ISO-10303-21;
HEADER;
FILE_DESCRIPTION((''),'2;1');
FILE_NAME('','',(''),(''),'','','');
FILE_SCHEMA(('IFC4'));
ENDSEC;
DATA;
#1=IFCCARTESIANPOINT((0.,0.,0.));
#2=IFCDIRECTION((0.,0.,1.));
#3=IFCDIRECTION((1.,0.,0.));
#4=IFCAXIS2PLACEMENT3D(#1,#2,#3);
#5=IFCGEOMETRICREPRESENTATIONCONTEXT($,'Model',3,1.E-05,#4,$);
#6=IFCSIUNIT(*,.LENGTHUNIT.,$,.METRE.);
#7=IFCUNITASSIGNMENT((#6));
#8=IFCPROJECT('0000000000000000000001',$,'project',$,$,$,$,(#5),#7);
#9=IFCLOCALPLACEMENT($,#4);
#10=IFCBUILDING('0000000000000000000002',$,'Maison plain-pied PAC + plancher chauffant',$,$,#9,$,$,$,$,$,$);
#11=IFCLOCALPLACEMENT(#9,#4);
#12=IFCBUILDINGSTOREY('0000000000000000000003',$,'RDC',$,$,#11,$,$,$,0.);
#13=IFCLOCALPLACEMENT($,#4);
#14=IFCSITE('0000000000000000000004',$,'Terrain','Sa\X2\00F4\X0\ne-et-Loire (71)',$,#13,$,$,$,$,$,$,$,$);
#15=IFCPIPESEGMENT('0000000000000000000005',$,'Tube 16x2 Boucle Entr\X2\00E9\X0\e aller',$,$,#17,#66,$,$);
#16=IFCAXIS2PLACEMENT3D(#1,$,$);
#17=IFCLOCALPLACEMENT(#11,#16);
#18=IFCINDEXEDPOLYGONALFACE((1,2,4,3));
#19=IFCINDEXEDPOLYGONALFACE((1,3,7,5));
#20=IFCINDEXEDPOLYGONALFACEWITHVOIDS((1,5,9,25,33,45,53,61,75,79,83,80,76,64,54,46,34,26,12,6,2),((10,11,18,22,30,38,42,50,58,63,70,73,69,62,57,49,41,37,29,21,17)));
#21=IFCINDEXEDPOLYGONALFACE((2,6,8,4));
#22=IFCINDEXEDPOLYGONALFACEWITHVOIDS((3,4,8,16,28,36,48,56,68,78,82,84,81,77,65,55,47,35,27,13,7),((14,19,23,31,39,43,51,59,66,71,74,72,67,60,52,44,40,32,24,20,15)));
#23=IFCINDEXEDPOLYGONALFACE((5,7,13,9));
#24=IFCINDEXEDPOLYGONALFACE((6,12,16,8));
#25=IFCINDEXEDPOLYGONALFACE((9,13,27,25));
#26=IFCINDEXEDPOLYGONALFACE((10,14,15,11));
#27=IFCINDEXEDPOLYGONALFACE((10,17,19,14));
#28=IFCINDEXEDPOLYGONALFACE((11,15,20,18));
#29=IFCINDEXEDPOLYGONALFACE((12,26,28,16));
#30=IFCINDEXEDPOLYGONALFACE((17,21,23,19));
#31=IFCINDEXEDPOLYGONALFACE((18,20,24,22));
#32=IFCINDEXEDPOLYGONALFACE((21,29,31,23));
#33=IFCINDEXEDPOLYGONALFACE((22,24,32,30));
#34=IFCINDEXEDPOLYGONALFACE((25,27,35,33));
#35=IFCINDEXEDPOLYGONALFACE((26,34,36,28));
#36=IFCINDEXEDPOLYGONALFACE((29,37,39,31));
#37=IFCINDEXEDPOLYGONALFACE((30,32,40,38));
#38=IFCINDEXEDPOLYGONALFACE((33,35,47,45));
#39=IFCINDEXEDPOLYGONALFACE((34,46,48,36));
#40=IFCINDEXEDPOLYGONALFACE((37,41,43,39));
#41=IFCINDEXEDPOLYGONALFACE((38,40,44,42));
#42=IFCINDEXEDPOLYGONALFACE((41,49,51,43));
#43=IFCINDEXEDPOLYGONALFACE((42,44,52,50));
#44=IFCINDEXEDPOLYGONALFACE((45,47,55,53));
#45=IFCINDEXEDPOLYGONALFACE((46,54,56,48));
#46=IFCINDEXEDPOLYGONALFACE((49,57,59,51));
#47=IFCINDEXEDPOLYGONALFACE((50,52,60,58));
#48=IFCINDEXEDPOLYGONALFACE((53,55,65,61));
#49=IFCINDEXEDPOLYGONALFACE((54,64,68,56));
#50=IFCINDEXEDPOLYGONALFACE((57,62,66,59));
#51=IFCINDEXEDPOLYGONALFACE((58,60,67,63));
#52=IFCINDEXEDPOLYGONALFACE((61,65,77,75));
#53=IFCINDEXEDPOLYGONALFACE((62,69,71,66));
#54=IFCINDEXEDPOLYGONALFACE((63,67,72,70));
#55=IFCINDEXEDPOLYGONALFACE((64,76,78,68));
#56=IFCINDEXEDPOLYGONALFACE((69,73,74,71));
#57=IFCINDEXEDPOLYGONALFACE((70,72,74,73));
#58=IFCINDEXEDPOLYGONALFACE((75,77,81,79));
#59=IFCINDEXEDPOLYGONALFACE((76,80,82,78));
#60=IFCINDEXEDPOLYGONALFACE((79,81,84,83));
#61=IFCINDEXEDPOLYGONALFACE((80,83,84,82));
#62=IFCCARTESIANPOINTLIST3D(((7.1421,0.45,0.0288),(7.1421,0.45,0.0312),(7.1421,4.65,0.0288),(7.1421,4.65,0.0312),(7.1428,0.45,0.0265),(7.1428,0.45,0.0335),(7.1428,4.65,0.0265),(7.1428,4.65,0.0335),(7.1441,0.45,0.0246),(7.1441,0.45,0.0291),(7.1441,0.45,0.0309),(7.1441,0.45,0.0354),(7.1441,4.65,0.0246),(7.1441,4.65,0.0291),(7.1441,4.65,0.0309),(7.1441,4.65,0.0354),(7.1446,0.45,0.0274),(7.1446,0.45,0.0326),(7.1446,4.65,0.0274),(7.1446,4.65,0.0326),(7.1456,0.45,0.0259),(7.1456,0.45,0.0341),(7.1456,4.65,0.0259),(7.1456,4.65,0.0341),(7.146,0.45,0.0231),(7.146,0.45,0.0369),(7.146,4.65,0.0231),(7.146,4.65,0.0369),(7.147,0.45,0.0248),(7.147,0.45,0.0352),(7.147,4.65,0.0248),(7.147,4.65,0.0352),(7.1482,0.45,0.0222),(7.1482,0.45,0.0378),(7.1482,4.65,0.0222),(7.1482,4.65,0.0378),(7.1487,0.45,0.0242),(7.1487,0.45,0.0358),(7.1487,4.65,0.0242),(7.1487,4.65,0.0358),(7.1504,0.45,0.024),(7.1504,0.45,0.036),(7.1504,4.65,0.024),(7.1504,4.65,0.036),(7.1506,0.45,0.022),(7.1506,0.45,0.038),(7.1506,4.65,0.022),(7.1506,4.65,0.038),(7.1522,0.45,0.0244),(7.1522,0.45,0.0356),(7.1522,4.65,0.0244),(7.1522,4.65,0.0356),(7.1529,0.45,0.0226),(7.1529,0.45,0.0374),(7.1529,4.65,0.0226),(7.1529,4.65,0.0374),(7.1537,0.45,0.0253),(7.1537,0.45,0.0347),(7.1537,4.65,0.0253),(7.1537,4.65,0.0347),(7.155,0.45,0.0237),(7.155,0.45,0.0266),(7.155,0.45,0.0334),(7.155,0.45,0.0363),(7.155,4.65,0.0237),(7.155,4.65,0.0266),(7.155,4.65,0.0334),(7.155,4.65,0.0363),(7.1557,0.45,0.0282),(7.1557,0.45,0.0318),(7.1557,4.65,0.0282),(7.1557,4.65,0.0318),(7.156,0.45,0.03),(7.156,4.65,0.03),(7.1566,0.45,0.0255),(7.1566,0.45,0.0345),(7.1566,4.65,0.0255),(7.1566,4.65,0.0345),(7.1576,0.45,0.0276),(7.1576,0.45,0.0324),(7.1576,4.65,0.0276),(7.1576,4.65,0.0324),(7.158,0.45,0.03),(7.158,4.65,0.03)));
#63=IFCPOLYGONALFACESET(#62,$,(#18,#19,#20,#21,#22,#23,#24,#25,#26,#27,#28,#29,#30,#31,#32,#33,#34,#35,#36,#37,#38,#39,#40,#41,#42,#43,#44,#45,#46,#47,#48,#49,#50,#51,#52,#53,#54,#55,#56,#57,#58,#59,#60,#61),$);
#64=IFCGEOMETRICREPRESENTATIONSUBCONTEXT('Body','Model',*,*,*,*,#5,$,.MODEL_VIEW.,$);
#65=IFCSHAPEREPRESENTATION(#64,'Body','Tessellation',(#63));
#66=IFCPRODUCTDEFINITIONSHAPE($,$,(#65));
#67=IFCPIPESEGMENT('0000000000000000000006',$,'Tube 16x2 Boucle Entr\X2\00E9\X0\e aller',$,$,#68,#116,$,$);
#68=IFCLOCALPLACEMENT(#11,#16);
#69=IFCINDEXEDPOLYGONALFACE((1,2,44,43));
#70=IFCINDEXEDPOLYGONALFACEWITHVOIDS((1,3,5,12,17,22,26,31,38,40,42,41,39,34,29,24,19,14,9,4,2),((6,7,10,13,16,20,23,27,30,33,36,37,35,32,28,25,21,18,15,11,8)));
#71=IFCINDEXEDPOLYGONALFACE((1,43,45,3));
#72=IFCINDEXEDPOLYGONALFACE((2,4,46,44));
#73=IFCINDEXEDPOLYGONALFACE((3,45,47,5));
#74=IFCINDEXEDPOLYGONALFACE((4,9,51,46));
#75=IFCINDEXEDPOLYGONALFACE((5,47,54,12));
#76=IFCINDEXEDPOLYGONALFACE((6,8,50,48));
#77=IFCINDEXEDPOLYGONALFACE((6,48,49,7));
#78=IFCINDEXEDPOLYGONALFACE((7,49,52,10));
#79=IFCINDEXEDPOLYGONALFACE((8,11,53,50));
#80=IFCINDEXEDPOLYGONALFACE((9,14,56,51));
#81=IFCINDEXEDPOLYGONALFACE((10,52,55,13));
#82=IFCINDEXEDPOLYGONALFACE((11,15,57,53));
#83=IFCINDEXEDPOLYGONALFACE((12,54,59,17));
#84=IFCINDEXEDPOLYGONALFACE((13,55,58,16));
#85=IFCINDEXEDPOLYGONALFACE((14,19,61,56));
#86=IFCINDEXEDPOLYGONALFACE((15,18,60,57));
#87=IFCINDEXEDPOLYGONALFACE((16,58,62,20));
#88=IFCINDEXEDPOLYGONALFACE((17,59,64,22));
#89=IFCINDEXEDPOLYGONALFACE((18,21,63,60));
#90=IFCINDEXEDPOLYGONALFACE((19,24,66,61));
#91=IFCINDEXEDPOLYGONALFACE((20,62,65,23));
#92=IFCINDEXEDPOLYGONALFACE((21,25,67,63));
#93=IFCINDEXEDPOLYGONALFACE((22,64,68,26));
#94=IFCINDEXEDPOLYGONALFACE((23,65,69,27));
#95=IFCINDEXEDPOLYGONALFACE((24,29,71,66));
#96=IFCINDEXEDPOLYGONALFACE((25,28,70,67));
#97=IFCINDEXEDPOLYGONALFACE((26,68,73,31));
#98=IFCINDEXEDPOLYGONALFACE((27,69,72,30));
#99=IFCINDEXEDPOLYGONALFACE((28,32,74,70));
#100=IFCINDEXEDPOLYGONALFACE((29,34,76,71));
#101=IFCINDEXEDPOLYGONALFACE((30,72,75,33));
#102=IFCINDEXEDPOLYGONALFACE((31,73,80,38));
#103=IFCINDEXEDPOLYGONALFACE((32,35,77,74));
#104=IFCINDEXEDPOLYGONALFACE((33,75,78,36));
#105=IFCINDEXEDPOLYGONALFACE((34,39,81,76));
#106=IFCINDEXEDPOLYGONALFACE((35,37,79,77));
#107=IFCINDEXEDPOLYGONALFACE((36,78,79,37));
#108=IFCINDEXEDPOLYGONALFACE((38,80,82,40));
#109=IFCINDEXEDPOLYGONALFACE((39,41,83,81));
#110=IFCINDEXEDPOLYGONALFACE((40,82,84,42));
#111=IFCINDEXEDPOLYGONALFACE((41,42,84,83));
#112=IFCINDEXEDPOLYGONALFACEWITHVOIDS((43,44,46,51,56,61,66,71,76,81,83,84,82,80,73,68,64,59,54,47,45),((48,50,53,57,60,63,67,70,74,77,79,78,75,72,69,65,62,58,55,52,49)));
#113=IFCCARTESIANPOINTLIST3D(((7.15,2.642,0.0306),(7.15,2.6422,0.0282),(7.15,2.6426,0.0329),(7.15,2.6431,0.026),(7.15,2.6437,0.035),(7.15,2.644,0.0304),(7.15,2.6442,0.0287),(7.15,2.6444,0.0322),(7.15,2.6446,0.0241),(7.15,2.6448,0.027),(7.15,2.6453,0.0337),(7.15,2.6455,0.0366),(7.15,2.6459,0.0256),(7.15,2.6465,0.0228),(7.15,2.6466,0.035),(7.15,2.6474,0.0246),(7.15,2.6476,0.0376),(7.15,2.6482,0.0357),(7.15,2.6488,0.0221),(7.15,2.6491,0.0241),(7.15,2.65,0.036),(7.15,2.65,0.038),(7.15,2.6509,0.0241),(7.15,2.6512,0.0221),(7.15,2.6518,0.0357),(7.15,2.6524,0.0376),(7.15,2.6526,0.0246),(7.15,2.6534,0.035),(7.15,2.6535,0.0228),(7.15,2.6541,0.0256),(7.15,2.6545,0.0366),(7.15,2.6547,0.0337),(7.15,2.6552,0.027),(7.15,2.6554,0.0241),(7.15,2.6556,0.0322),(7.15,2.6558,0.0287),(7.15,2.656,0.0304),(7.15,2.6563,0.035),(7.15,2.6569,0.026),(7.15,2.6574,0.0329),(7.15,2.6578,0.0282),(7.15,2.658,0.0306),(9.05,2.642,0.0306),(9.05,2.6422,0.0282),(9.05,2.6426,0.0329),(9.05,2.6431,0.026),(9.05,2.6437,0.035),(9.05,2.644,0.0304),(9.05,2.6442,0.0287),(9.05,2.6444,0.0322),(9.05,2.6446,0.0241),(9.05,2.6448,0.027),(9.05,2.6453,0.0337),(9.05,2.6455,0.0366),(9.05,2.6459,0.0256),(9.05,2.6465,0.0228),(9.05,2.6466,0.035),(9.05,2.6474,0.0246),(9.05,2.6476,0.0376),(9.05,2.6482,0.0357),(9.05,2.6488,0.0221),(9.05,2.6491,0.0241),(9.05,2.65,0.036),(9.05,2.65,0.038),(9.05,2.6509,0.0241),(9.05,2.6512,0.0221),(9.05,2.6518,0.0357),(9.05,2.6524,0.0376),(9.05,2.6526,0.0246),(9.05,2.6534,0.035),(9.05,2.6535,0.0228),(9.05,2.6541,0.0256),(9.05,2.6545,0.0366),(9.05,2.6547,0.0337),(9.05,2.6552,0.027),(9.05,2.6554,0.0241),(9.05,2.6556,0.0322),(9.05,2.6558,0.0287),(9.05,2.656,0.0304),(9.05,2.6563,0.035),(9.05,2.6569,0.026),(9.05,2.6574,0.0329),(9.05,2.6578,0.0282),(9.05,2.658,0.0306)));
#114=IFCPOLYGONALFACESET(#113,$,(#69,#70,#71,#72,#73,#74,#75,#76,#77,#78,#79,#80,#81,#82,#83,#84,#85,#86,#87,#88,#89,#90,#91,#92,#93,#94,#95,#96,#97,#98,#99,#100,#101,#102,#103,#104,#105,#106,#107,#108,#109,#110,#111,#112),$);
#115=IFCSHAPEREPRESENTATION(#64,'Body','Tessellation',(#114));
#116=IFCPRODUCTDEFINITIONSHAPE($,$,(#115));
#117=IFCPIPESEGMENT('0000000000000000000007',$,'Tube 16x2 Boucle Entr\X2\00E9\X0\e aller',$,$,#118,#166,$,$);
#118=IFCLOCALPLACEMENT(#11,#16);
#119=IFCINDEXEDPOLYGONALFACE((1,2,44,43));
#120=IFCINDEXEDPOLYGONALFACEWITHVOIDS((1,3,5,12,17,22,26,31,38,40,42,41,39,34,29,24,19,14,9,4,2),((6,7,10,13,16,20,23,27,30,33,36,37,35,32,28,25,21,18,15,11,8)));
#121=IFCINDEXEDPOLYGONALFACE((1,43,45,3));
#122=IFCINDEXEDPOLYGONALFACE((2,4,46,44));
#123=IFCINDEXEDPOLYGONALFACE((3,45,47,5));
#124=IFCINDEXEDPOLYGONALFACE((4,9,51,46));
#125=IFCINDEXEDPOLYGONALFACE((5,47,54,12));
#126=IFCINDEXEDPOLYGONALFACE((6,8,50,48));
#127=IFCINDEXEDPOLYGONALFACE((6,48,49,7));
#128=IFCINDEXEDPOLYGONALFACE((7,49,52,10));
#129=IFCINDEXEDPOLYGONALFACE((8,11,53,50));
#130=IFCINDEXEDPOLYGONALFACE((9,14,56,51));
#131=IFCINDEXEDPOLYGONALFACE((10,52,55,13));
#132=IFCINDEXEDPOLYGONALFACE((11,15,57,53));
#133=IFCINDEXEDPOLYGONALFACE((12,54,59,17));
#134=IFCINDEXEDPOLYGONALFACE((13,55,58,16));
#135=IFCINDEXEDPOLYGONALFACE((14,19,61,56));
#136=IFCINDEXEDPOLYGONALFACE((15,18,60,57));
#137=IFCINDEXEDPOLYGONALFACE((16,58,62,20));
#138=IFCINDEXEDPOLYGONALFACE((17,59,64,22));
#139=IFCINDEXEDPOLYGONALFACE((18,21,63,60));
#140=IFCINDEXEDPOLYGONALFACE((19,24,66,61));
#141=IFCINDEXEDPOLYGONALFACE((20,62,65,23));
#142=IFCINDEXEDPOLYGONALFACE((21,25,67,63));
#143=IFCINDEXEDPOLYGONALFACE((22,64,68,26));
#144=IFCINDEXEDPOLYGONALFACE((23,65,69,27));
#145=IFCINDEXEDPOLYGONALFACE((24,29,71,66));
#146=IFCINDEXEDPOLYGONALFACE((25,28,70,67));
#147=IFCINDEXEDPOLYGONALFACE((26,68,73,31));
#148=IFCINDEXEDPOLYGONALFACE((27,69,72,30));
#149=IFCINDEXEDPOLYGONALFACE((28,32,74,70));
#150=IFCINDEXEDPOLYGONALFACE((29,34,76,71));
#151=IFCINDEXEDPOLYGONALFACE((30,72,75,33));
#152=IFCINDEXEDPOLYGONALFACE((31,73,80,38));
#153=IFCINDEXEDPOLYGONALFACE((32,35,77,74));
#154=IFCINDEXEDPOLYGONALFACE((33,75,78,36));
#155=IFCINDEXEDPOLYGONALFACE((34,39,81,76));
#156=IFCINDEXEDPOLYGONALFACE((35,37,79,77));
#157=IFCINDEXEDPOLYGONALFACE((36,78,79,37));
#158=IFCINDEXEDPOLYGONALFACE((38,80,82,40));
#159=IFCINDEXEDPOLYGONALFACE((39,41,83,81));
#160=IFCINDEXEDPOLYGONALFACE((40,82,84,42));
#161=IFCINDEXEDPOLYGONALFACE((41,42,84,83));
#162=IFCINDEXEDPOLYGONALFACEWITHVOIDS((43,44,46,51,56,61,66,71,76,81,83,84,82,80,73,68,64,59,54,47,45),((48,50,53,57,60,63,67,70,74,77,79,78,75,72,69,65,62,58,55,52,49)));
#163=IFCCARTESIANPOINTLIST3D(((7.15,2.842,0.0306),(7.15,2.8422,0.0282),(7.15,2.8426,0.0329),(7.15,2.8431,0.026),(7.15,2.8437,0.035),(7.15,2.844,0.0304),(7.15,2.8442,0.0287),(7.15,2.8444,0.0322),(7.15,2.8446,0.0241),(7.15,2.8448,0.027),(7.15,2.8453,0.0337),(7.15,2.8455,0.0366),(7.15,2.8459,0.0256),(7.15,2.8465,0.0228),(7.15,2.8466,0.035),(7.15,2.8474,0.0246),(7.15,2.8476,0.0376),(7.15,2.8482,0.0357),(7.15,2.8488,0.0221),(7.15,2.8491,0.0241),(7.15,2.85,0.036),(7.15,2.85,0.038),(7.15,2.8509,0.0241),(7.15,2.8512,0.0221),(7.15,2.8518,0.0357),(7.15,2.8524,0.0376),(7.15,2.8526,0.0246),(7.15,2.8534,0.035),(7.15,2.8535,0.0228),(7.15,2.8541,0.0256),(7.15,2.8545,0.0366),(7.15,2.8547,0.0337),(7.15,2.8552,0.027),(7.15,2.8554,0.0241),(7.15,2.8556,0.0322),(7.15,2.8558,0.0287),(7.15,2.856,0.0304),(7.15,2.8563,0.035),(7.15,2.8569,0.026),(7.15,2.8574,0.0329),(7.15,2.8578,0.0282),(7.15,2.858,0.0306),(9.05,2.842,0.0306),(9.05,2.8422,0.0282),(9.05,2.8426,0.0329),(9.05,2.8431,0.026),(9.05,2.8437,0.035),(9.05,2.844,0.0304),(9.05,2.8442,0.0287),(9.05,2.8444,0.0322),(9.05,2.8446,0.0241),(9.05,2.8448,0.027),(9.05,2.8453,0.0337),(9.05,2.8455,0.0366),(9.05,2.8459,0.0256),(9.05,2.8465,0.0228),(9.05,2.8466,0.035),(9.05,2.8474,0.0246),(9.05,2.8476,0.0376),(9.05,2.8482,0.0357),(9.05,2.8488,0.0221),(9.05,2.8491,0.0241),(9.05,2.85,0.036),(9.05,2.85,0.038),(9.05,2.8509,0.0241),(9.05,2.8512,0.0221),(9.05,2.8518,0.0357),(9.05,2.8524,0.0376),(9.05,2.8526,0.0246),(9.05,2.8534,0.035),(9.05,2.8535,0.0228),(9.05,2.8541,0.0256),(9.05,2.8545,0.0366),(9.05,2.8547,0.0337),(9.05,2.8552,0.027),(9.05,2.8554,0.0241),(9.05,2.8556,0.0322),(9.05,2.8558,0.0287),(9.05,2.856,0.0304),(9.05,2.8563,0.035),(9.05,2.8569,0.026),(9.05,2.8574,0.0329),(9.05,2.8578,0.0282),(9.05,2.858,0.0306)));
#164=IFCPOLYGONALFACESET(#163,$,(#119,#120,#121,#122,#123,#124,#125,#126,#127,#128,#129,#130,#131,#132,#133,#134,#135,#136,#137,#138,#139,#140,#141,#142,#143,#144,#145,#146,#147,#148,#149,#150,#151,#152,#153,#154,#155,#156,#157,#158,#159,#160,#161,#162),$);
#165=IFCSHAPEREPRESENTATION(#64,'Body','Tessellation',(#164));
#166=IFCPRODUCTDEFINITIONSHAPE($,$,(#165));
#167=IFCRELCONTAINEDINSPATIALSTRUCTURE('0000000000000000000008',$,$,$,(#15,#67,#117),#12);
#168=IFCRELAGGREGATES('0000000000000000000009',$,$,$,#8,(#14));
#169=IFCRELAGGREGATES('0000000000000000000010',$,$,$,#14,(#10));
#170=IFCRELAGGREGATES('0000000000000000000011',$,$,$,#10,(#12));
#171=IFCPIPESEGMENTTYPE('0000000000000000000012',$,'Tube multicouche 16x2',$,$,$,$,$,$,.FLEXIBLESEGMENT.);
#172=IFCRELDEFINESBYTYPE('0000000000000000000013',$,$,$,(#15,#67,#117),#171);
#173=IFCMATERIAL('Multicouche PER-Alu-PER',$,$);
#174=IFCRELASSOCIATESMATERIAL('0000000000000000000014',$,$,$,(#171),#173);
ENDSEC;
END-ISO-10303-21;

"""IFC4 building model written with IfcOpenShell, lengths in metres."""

from ifc_helpers import new_model, si_unit, frame, origin_with_axes, place, context, subcontext, project, spatial, hollow_circle, extrude, material, type_object, element, save


model = new_model("IFC4")

# Units and contexts
model_context = context("Model", 3, precision=1e-05, world=origin_with_axes())
body_context = subcontext(model_context, "Body", "Model", "MODEL_VIEW")
ifc_project = project(units=[si_unit("LENGTHUNIT", "METRE")], contexts=[model_context])

# Site, building, storey
site_placement = place(None, origin_with_axes())
site = spatial("IfcSite", under=ifc_project, at=site_placement, Name="Terrain", Description="Saône-et-Loire (71)")
building_placement = place(None, origin_with_axes())
building = spatial("IfcBuilding", under=site, at=building_placement, Name="Maison plain-pied PAC + plancher chauffant")
storey_placement = place(building_placement, origin_with_axes())
storey = spatial("IfcBuildingStorey", under=building, at=storey_placement, Name="RDC", Elevation=0.0)

# Pipe segments
ifc_material = material(Name="Multicouche PER-Alu-PER")
pipe_segment_type = type_object("IfcPipeSegmentType", Name="Tube multicouche 16x2", PredefinedType="FLEXIBLESEGMENT", material=ifc_material)
pipe_segment_1_placement = place(storey_placement, frame((7.15, 4.65, 0.03), z_axis=(0.0, -1.0, 0.0), x_axis=(1.0, 0.0, 0.0)))
element("IfcPipeSegment", 1, at=pipe_segment_1_placement, inside=storey, type_object=pipe_segment_type, Name="Tube 16x2 Boucle Entrée aller", context=body_context, shape_type="SweptSolid", body=[
    extrude(hollow_circle(Radius=0.008, WallThickness=0.002), origin_with_axes(), (0.0, 0.0, 1.0), 4.2),
])
for number, where, z_axis, x_axis, name in (
    (2, (9.05, 2.65, 0.03), (-1.0, 0.0, 0.0), (0.0, 0.0, 1.0), "Tube 16x2 Boucle Entrée aller"),
    (3, (7.15, 2.85, 0.03), (1.0, 0.0, 0.0), (0.0, 0.0, 1.0), "Tube 16x2 Boucle Entrée aller"),
):
    element("IfcPipeSegment", number, at=place(storey_placement, frame(where, z_axis=z_axis, x_axis=x_axis)), inside=storey, type_object=pipe_segment_type, Name=name, context=body_context, shape_type="SweptSolid", body=[
        extrude(hollow_circle(Radius=0.008, WallThickness=0.002), origin_with_axes(), (0.0, 0.0, 1.0), 1.9),
    ])

save(model, "model.ifc")
